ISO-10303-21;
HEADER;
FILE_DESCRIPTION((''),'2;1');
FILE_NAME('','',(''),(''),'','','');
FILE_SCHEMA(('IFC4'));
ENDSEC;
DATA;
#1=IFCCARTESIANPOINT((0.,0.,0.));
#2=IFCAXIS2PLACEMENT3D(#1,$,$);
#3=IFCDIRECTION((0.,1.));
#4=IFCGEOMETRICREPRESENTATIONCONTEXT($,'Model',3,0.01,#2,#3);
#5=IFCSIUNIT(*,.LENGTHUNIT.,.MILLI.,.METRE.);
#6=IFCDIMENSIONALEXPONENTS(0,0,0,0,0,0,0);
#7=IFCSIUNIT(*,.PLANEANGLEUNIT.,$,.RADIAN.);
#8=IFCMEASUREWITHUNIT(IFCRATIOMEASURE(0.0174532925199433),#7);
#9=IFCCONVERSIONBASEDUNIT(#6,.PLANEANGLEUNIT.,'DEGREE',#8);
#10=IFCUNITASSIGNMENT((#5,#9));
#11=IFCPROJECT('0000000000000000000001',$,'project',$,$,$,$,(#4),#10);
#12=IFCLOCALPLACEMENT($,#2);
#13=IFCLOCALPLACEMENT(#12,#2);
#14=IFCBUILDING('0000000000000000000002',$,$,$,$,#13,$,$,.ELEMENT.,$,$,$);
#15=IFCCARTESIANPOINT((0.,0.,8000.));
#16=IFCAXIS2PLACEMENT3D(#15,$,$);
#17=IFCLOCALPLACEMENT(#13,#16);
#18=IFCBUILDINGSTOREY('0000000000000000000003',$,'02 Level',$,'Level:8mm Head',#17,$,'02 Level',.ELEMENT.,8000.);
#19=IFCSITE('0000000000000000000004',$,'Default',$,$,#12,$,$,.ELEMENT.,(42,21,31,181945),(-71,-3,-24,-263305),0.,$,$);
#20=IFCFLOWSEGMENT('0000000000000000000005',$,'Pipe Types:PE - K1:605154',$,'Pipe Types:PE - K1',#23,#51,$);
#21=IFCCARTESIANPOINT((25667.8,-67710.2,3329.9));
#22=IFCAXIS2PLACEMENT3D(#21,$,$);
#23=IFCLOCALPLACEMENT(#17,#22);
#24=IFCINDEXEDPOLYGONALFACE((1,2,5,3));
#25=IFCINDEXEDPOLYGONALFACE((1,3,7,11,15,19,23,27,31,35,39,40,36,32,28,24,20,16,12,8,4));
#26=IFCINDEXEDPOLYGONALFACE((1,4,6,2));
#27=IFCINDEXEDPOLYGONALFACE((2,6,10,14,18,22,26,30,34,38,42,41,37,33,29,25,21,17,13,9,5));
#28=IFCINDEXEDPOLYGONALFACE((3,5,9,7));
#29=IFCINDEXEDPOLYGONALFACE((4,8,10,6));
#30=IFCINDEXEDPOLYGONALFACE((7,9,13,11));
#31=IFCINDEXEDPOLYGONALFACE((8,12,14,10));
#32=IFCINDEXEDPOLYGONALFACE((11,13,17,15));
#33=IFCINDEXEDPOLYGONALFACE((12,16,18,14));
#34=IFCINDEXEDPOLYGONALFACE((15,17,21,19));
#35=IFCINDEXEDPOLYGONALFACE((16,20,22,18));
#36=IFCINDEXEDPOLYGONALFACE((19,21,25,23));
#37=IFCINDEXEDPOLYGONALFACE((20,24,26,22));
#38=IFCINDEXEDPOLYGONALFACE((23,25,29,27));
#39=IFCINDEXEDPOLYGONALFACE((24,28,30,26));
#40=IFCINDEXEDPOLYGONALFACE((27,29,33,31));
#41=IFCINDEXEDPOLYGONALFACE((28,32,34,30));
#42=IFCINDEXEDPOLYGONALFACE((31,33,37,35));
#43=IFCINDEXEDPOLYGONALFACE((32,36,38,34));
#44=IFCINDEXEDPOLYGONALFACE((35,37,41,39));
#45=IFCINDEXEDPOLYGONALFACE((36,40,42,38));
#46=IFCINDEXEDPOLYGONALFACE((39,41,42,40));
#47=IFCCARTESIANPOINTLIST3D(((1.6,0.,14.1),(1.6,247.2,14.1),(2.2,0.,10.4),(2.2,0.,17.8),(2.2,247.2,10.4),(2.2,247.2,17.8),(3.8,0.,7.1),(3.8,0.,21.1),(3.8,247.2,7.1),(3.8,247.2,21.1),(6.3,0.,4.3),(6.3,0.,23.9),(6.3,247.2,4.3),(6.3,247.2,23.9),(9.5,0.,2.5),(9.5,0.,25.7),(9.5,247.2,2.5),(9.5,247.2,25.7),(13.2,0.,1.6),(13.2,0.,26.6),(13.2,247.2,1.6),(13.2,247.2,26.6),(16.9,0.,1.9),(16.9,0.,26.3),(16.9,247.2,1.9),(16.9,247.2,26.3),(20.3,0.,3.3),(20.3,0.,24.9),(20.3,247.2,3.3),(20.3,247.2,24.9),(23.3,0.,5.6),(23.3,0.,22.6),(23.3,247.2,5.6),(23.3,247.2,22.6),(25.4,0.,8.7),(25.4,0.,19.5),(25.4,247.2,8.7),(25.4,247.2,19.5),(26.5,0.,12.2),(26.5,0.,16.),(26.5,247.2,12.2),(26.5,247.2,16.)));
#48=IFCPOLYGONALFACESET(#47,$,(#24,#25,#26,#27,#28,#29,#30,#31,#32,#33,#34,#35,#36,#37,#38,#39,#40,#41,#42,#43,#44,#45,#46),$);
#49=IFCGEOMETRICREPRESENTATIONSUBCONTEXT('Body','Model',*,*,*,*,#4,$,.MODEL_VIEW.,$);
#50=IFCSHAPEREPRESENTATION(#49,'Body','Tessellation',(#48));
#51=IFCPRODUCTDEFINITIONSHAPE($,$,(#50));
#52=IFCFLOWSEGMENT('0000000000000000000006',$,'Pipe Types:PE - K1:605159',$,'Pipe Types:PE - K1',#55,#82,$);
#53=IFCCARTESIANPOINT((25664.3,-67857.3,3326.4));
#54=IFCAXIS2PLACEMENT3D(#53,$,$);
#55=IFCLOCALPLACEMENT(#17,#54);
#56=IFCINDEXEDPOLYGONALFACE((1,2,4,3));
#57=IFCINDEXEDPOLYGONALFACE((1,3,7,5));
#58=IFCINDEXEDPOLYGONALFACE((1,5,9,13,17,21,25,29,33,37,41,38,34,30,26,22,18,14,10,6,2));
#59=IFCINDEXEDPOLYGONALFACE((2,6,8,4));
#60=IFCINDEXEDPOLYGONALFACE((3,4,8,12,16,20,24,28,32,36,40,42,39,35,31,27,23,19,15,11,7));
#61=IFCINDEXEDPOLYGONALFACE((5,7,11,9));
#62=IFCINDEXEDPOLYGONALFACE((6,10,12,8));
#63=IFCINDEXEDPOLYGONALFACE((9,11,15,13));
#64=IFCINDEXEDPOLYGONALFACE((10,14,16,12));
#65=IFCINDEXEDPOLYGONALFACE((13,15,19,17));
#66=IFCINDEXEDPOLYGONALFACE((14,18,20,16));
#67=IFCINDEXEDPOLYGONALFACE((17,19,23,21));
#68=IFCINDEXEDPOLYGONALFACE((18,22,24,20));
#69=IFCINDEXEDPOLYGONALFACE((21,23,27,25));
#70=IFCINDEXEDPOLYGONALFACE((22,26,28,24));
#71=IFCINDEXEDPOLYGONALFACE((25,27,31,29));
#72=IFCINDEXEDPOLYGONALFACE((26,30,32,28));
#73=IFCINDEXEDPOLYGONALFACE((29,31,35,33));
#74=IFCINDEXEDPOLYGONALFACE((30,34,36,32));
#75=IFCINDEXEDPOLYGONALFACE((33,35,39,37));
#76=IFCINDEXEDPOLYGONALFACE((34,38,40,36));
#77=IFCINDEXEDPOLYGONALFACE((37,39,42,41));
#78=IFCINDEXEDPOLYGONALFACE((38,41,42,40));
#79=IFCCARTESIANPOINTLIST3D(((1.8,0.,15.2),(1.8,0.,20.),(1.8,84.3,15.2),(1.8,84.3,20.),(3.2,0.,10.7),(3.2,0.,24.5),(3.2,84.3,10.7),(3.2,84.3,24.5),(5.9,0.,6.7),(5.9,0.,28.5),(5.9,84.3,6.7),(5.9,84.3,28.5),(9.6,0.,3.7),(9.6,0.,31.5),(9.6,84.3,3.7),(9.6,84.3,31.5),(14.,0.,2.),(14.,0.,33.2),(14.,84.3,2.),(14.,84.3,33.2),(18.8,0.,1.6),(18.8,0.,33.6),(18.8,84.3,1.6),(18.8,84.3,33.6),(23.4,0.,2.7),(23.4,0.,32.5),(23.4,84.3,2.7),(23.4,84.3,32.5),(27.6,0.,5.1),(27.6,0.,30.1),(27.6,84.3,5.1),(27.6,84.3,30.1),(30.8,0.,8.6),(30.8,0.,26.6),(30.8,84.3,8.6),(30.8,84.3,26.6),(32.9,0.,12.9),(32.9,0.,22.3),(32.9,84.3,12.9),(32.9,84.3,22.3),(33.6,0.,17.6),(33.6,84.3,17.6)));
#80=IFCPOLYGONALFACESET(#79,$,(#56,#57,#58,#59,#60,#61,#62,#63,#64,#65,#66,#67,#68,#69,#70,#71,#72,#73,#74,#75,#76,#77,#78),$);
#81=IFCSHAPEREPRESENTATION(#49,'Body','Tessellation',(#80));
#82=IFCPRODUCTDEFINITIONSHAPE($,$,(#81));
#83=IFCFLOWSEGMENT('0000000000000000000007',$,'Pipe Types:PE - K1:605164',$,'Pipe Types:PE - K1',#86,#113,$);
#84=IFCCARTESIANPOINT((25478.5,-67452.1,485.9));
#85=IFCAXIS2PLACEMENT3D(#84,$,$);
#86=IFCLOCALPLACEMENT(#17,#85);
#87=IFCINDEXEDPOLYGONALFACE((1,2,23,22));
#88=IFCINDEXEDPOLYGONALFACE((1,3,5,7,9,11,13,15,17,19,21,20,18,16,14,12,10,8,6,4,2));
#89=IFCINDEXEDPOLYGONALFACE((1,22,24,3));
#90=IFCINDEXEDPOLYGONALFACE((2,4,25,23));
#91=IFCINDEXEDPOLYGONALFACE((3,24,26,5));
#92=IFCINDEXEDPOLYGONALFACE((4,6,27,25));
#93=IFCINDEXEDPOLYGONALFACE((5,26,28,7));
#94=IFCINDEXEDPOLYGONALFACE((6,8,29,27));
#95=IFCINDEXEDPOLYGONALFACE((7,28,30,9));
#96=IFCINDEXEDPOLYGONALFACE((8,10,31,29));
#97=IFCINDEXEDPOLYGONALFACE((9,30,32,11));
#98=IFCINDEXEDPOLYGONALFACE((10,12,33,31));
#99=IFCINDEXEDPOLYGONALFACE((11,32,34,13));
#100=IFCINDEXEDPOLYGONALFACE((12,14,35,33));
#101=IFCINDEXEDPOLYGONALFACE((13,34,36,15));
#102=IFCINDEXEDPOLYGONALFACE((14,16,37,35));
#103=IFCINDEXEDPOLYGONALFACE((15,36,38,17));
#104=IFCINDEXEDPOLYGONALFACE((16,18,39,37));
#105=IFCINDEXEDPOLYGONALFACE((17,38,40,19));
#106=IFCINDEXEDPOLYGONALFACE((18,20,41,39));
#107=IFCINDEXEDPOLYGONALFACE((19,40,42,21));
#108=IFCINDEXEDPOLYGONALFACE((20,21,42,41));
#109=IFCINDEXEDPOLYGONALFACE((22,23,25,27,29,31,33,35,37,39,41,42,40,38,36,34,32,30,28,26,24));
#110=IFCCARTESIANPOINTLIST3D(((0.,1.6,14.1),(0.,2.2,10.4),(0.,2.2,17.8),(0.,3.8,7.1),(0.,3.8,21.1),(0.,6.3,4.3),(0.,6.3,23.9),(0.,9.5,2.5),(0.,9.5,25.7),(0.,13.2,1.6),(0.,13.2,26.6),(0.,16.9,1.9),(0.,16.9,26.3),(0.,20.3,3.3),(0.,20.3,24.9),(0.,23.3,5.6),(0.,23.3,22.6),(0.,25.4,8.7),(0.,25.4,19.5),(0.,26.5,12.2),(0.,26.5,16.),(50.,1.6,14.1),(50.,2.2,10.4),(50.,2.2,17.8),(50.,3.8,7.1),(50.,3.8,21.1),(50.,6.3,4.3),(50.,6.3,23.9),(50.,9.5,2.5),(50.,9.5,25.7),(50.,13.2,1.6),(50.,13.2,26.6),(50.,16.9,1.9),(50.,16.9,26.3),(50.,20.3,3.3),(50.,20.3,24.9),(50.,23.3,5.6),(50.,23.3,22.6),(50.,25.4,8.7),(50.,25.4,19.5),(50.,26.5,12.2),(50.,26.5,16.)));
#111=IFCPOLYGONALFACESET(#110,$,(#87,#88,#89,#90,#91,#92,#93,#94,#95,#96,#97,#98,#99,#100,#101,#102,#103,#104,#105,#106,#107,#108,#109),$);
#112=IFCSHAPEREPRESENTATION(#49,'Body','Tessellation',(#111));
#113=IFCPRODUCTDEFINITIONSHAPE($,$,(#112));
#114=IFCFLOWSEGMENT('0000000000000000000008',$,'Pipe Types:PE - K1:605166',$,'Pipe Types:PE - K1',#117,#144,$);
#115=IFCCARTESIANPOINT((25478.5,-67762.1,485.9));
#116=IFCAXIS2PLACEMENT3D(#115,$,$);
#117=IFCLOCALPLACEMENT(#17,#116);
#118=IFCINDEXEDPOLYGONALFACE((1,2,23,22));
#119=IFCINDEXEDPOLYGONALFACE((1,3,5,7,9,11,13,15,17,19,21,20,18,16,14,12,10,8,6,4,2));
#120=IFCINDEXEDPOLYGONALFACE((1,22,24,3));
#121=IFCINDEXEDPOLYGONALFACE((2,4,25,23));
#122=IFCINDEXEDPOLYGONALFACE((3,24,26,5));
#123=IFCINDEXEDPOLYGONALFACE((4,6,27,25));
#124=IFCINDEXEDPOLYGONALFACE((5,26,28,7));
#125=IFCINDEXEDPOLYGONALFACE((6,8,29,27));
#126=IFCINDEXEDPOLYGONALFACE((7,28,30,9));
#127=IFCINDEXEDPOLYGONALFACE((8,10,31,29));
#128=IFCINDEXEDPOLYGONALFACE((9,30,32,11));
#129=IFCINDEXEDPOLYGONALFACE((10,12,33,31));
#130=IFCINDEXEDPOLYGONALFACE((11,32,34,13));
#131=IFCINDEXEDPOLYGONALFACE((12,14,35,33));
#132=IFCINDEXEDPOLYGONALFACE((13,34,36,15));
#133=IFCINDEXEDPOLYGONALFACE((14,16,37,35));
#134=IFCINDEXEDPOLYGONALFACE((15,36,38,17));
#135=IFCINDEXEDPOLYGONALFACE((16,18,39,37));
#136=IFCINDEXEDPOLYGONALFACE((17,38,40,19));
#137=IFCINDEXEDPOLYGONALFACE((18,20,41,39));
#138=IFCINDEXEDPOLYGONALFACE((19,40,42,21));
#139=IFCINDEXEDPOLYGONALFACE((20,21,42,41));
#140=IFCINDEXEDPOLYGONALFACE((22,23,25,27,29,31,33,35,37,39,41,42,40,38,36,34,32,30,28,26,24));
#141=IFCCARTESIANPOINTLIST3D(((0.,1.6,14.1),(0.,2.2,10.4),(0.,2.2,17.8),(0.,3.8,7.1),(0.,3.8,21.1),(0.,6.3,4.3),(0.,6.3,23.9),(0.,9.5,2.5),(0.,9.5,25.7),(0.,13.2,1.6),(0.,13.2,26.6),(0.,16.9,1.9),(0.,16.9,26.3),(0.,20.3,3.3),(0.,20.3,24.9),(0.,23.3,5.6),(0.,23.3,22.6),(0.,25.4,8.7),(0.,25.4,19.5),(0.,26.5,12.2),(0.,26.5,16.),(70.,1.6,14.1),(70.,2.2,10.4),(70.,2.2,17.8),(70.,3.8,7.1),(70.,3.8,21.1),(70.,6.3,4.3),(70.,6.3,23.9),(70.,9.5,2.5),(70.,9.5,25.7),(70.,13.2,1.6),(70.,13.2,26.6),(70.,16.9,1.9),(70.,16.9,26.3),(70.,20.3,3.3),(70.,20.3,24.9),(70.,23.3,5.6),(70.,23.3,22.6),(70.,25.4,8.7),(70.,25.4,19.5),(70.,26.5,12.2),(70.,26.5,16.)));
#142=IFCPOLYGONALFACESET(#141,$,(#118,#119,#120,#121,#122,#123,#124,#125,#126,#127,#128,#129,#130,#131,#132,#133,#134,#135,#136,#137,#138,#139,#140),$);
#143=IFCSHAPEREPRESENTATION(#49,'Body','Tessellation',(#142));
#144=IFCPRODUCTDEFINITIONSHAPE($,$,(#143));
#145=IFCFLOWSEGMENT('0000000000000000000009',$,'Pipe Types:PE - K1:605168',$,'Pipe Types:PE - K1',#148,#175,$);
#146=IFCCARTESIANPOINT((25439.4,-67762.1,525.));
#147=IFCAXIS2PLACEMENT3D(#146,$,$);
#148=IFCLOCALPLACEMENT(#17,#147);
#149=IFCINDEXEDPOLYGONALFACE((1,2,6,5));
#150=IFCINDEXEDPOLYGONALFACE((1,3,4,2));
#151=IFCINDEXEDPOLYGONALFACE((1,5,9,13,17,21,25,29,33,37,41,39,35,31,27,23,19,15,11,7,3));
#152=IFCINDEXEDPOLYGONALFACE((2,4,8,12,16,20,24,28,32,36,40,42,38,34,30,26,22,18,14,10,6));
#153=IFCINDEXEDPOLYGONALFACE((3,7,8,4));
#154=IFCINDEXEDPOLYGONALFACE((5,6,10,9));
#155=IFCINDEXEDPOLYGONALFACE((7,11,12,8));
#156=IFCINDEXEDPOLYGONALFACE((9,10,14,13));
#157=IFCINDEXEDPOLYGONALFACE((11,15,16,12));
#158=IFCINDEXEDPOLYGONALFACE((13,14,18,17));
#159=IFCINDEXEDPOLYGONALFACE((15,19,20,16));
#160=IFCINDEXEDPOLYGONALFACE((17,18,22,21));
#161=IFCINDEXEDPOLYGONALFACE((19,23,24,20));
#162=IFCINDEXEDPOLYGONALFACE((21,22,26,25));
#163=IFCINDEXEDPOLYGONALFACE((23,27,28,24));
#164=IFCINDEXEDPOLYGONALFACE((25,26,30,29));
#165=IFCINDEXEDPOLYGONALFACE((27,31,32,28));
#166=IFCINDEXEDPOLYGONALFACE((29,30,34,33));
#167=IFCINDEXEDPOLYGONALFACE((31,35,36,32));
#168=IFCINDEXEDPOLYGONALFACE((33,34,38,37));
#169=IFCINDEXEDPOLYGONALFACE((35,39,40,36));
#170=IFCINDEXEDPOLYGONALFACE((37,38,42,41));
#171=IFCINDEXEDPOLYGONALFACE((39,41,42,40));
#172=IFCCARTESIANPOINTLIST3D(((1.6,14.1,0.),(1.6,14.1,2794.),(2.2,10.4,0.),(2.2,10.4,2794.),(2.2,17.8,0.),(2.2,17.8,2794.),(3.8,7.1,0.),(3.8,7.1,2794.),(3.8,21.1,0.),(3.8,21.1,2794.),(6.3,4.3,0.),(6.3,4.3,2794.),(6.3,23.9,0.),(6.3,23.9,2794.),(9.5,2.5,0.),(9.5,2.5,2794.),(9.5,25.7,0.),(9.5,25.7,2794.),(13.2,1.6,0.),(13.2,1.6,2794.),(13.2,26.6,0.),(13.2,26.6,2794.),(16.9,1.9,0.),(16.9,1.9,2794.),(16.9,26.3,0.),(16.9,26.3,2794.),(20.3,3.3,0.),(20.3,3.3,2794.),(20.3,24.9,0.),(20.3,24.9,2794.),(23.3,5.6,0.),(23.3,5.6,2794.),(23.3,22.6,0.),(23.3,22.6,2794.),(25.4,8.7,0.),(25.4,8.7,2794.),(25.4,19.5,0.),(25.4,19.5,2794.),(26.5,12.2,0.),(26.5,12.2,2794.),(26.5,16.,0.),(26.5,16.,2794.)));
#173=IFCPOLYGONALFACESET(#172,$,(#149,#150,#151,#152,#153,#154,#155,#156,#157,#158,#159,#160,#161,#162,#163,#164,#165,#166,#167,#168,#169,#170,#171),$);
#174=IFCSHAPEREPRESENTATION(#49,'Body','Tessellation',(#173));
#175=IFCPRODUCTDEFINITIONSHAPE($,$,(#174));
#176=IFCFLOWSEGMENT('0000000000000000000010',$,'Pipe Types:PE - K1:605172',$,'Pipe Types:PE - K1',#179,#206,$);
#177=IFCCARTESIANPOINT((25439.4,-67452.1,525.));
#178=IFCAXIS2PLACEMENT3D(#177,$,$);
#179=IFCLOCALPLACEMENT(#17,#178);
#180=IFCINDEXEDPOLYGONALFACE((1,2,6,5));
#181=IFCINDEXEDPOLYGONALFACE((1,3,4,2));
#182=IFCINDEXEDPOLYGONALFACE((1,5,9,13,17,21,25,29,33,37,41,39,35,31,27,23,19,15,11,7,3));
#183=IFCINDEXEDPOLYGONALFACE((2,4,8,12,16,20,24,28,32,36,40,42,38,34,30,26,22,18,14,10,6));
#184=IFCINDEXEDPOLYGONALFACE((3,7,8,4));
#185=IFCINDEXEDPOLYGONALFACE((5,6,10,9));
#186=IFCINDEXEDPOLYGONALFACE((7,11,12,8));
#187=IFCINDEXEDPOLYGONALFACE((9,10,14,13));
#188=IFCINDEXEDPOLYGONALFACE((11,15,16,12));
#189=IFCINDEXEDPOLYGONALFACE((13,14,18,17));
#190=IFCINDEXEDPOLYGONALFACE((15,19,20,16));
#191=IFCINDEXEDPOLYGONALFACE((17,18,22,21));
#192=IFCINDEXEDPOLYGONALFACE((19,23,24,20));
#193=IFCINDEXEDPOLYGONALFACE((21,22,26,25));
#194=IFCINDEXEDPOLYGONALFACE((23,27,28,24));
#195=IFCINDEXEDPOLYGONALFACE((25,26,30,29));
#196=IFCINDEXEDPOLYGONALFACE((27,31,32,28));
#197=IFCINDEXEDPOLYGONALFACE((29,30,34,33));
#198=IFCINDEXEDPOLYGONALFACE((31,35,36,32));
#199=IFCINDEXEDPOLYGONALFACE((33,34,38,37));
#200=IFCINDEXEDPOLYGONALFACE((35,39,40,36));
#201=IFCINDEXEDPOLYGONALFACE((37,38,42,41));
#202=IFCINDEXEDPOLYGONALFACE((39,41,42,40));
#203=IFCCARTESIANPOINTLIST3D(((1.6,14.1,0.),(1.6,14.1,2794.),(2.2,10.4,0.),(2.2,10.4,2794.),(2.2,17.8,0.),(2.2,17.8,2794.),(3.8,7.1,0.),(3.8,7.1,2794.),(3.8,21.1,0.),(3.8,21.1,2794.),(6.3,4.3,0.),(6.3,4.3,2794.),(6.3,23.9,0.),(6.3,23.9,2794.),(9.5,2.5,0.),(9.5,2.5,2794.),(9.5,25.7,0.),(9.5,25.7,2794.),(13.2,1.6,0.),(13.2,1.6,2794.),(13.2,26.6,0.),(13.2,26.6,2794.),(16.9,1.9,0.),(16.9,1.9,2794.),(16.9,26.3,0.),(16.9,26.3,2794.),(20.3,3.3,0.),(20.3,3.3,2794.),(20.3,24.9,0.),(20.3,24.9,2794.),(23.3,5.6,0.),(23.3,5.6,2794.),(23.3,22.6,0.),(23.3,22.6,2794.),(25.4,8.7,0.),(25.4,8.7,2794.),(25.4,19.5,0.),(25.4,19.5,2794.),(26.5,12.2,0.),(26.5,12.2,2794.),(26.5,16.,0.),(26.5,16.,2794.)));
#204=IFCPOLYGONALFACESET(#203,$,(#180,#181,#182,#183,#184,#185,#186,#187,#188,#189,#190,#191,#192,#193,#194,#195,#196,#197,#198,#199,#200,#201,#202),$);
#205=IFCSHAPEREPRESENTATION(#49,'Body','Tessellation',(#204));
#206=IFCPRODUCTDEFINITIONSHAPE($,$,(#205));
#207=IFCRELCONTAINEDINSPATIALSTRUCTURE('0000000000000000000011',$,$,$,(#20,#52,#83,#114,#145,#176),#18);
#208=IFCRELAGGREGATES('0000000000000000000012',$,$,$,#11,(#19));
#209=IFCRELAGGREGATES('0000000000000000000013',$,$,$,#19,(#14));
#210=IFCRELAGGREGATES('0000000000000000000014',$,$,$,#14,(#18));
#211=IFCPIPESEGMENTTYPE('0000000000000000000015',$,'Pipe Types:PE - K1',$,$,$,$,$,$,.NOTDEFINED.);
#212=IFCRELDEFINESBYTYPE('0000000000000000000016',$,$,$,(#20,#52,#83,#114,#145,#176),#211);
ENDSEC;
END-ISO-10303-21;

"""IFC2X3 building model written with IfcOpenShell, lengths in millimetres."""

from ifc_helpers import new_model, entity, si_unit, converted_unit, direction, frame, frame_2d, origin, origin_2d_with_axis, place, context, subcontext, project, spatial, circle, extrude, type_object, element, save


model = new_model("IFC2X3")

# Units and contexts
model_context = context("Model", 3, precision=0.01, world=origin(), true_north=direction((0.0, 1.0)))
body_context = subcontext(model_context, "Body", "Model", "MODEL_VIEW")
ifc_project = project(units=[si_unit("LENGTHUNIT", "METRE", prefix="MILLI"), converted_unit("PLANEANGLEUNIT", "DEGREE", entity("IfcRatioMeasure", 0.0174532925199433), si_unit("PLANEANGLEUNIT", "RADIAN"), dimensions=[0, 0, 0, 0, 0, 0, 0])], contexts=[model_context])

# Site, building, storey
site_placement = place(None, origin())
site = spatial("IfcSite", under=ifc_project, at=site_placement, Name="Default", CompositionType="ELEMENT", RefLatitude=(42, 21, 31, 181945), RefLongitude=(-71, -3, -24, -263305), RefElevation=0.0)
building_placement = place(site_placement, origin())
building = spatial("IfcBuilding", under=site, at=building_placement, CompositionType="ELEMENT")
storey_placement = place(building_placement, frame((0.0, 0.0, 8000.0)))
storey = spatial("IfcBuildingStorey", under=building, at=storey_placement, Name="02 Level", ObjectType="Level:8mm Head", LongName="02 Level", CompositionType="ELEMENT", Elevation=8000.0)

# Flow segments
pipe_segment_type = type_object("IfcPipeSegmentType", Name="Pipe Types:PE - K1", PredefinedType="NOTDEFINED")
flow_segment_1_placement = place(storey_placement, frame((25667.8, -67710.2, 3329.9)))
element("IfcFlowSegment", 1, at=flow_segment_1_placement, inside=storey, type_object=pipe_segment_type, Name="Pipe Types:PE - K1:605154", ObjectType="Pipe Types:PE - K1", context=body_context, shape_type="SweptSolid", body=[
    extrude(circle(Radius=12.5, at=origin_2d_with_axis()), frame((14.1, 0.0, 14.1), z_axis=(0.0, 1.0, 0.0), x_axis=(-1.0, 0.0, 0.0)), (0.0, 0.0, 1.0), 247.2),
])
flow_segment_2_placement = place(storey_placement, frame((25664.3, -67857.3, 3326.4)))
element("IfcFlowSegment", 2, at=flow_segment_2_placement, inside=storey, type_object=pipe_segment_type, Name="Pipe Types:PE - K1:605159", ObjectType="Pipe Types:PE - K1", context=body_context, shape_type="SweptSolid", body=[
    extrude(circle(Radius=16.0, at=origin_2d_with_axis()), frame((17.6, 0.0, 17.6), z_axis=(0.0, 1.0, 0.0), x_axis=(1.0, 0.0, 0.0)), (0.0, 0.0, 1.0), 84.3),
])
flow_segment_3_placement = place(storey_placement, frame((25478.5, -67452.1, 485.9)))
element("IfcFlowSegment", 3, at=flow_segment_3_placement, inside=storey, type_object=pipe_segment_type, Name="Pipe Types:PE - K1:605164", ObjectType="Pipe Types:PE - K1", context=body_context, shape_type="SweptSolid", body=[
    extrude(circle(Radius=12.5, at=frame_2d((0.0, 0.0), x_axis=(1.0, 0.0))), frame((0.0, 14.1, 14.1), z_axis=(1.0, 0.0, 0.0), x_axis=(0.0, -1.0, 0.0)), (0.0, 0.0, 1.0), 50.0),
])
flow_segment_4_placement = place(storey_placement, frame((25478.5, -67762.1, 485.9)))
element("IfcFlowSegment", 4, at=flow_segment_4_placement, inside=storey, type_object=pipe_segment_type, Name="Pipe Types:PE - K1:605166", ObjectType="Pipe Types:PE - K1", context=body_context, shape_type="SweptSolid", body=[
    extrude(circle(Radius=12.5, at=frame_2d((0.0, 0.0), x_axis=(1.0, 0.0))), frame((0.0, 14.1, 14.1), z_axis=(1.0, 0.0, 0.0), x_axis=(0.0, -1.0, 0.0)), (0.0, 0.0, 1.0), 70.0),
])
flow_segment_5_placement = place(storey_placement, frame((25439.4, -67762.1, 525.0)))
element("IfcFlowSegment", 5, at=flow_segment_5_placement, inside=storey, type_object=pipe_segment_type, Name="Pipe Types:PE - K1:605168", ObjectType="Pipe Types:PE - K1", context=body_context, shape_type="SweptSolid", body=[
    extrude(circle(Radius=12.5, at=origin_2d_with_axis()), frame((14.1, 14.1, 0.0), z_axis=(0.0, 0.0, 1.0), x_axis=(-1.0, 0.0, 0.0)), (0.0, 0.0, 1.0), 2794.0),
])
flow_segment_6_placement = place(storey_placement, frame((25439.4, -67452.1, 525.0)))
element("IfcFlowSegment", 6, at=flow_segment_6_placement, inside=storey, type_object=pipe_segment_type, Name="Pipe Types:PE - K1:605172", ObjectType="Pipe Types:PE - K1", context=body_context, shape_type="SweptSolid", body=[
    extrude(circle(Radius=12.5, at=origin_2d_with_axis()), frame((14.1, 14.1, 0.0), z_axis=(0.0, 0.0, 1.0), x_axis=(-1.0, 0.0, 0.0)), (0.0, 0.0, 1.0), 2794.0),
])

save(model, "model.ifc")
